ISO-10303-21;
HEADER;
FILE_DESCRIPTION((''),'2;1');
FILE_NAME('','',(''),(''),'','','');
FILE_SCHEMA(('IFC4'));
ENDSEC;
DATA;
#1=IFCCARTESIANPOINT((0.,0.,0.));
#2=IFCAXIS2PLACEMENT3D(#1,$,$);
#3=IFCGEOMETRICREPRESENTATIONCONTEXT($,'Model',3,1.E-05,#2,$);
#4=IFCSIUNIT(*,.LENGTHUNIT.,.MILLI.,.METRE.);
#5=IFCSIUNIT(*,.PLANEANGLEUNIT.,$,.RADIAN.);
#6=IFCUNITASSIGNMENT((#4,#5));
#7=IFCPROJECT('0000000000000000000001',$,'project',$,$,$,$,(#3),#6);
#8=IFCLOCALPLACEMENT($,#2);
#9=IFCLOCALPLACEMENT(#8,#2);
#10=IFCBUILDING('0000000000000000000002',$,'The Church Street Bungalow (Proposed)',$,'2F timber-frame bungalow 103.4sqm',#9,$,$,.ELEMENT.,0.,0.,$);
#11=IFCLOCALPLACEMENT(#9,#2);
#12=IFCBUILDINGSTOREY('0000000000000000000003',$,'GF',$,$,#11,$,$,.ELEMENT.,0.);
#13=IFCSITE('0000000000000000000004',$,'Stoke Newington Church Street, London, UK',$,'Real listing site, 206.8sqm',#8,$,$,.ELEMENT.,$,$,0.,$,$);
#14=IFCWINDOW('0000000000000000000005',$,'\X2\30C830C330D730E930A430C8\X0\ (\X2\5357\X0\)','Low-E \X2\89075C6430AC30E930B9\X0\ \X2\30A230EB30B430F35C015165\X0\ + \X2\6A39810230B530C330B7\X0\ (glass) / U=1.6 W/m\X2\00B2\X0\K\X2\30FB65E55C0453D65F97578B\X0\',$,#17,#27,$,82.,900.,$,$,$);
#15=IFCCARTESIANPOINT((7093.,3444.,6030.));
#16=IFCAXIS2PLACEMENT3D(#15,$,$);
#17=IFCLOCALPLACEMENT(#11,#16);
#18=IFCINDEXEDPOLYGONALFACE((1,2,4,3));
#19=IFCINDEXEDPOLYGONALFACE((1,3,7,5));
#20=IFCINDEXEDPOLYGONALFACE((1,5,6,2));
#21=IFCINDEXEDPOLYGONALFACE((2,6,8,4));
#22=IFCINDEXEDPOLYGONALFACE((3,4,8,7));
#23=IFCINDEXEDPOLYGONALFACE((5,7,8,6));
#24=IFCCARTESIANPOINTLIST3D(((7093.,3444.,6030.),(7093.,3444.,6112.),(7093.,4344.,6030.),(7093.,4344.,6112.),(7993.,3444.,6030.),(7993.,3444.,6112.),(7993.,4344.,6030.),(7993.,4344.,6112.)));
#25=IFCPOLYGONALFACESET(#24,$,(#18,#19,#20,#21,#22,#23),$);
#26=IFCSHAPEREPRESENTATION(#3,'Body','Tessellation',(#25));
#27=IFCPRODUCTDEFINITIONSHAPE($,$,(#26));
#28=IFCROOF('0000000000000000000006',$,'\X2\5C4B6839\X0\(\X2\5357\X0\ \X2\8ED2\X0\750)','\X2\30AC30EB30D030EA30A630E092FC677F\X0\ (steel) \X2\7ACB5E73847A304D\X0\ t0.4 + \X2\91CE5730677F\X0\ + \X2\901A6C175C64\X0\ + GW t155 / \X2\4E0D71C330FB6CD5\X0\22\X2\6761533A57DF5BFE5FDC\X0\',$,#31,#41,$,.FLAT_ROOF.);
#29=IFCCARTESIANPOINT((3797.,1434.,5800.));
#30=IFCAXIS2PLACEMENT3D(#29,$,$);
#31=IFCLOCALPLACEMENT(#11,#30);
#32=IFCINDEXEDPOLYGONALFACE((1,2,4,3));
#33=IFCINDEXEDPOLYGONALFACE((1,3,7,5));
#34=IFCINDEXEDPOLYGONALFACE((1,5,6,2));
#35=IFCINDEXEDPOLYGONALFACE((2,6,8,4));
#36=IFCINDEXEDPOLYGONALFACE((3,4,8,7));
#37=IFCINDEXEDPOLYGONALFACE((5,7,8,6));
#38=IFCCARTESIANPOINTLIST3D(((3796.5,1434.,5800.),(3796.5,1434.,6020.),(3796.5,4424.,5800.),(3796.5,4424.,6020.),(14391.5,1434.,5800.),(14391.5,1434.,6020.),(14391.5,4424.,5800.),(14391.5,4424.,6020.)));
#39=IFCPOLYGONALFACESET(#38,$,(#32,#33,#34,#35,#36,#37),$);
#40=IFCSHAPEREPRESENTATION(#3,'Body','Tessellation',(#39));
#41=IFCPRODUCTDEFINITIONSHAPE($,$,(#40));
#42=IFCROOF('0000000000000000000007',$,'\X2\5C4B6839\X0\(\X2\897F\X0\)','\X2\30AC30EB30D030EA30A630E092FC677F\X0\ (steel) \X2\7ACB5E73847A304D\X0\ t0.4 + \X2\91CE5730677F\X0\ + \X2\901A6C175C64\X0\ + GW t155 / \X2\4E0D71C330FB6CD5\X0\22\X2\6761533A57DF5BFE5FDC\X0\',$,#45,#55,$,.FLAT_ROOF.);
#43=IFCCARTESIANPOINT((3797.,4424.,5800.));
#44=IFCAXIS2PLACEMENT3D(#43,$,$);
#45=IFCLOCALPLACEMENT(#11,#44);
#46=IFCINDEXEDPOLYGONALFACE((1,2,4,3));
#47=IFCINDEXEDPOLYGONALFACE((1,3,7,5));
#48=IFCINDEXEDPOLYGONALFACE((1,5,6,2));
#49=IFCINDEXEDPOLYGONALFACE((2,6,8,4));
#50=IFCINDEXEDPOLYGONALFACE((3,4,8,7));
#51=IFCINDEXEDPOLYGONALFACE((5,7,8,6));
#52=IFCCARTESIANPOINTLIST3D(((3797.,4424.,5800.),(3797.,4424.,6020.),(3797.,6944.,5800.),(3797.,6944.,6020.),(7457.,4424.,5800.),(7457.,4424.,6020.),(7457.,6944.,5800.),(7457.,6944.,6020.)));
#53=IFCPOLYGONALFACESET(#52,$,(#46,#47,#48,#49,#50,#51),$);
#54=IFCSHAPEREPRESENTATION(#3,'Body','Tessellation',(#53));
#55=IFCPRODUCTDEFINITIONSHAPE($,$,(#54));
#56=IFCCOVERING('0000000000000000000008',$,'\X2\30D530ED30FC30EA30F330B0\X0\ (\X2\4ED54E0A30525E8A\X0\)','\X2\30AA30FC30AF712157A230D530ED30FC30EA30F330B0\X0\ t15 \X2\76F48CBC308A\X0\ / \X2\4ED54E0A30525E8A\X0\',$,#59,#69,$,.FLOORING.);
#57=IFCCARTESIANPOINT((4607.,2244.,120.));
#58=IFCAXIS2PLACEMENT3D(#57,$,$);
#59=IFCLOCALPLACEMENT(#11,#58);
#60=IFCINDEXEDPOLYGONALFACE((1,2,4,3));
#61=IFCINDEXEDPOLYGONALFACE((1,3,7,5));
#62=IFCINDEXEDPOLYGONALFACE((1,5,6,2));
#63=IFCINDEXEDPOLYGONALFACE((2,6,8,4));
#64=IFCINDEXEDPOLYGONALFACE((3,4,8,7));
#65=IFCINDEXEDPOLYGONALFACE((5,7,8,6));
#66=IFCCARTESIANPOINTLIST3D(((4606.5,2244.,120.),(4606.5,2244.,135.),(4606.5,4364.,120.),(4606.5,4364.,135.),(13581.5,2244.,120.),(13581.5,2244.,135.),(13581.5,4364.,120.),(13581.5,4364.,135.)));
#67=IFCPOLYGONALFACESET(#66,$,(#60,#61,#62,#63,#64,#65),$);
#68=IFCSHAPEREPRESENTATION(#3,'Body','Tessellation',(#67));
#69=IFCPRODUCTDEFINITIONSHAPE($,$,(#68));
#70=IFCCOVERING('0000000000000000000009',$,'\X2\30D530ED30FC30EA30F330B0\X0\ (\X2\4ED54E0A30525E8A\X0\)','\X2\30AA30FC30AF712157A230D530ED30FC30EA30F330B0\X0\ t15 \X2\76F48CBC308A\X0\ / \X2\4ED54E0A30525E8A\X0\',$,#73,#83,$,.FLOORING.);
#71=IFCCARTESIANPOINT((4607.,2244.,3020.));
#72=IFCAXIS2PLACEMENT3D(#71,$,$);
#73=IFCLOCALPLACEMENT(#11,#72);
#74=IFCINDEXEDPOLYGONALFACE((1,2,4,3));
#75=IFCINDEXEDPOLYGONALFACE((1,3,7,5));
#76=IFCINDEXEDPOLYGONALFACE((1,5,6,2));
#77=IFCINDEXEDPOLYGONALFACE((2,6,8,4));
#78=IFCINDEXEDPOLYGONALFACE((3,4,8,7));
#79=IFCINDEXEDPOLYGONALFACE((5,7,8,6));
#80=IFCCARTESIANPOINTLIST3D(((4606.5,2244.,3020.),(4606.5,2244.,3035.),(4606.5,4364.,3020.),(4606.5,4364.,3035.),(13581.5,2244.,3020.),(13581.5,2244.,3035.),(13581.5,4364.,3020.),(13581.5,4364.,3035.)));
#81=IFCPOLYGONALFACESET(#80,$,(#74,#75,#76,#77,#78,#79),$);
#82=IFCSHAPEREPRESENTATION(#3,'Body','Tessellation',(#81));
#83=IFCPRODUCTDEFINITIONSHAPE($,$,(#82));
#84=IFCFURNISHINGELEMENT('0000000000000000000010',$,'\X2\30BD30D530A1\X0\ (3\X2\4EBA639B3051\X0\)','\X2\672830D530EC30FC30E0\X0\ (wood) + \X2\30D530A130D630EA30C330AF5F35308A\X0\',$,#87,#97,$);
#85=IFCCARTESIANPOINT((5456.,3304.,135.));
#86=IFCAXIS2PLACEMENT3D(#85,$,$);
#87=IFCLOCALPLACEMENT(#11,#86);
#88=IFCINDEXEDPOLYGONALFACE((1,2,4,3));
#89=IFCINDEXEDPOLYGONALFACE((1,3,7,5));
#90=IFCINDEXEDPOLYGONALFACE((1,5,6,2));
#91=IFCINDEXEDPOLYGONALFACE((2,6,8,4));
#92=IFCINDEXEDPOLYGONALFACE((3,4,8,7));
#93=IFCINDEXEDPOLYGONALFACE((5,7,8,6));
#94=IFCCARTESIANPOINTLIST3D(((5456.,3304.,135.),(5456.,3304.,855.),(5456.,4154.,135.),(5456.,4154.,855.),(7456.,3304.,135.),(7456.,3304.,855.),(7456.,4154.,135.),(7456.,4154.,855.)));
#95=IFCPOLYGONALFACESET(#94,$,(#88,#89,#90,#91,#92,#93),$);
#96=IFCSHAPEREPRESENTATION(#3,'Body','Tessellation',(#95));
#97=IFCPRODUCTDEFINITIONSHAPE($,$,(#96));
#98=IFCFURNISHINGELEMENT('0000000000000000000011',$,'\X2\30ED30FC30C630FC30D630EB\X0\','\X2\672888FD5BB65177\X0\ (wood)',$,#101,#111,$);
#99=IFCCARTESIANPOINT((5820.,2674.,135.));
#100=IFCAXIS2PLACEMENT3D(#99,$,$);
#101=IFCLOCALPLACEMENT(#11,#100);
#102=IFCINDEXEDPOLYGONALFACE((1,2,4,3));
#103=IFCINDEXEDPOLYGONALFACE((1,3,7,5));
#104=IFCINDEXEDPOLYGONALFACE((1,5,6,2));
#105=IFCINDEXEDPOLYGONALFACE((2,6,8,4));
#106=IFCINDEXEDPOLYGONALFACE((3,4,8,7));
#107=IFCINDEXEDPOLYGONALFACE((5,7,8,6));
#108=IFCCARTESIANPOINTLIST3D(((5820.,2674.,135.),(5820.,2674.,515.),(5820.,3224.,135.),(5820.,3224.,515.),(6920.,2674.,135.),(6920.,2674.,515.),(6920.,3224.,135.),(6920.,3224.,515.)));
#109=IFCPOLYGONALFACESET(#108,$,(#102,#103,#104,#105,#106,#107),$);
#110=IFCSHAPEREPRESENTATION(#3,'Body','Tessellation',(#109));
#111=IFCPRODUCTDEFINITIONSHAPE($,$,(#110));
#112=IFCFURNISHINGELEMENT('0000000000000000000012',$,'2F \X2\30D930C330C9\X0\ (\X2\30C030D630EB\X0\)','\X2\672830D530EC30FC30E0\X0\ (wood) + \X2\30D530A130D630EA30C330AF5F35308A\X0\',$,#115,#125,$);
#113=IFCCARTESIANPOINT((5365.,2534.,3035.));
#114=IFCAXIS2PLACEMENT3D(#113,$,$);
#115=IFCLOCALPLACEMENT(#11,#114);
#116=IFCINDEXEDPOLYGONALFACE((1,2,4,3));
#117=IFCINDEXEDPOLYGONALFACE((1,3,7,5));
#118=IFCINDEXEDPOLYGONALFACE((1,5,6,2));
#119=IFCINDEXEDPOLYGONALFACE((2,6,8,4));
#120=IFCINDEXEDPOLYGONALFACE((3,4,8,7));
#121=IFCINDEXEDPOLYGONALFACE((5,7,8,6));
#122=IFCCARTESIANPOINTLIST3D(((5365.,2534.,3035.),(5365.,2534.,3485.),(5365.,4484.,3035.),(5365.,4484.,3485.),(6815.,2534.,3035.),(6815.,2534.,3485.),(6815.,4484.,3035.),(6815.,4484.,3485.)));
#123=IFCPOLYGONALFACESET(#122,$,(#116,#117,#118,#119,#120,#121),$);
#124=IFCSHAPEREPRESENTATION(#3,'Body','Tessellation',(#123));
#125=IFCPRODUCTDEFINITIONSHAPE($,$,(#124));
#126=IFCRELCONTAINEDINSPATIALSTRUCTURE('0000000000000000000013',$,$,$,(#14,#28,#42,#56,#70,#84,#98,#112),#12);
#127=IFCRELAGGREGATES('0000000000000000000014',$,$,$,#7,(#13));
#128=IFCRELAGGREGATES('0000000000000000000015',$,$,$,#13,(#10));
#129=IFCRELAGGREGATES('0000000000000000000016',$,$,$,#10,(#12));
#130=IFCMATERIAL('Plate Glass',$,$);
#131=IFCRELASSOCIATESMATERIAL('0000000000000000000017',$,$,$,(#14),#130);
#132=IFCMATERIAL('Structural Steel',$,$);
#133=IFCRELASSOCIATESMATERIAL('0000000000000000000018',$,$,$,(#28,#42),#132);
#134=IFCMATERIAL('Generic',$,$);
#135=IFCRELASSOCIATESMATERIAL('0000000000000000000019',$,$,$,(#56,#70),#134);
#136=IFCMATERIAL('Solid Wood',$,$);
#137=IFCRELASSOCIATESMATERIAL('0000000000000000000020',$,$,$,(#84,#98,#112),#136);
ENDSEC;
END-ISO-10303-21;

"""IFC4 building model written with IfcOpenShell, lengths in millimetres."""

from ifc_helpers import new_model, si_unit, frame, frame_2d, origin, place, context, project, spatial, rectangle, extrude, material, element, save


model = new_model("IFC4")

# Units and contexts
model_context = context("Model", 3, precision=1e-05, world=origin())
ifc_project = project(units=[si_unit("LENGTHUNIT", "METRE", prefix="MILLI"), si_unit("PLANEANGLEUNIT", "RADIAN")], contexts=[model_context])

# Site, building, storey
site_placement = place(None, origin())
site = spatial("IfcSite", under=ifc_project, at=site_placement, Name="Stoke Newington Church Street, London, UK", ObjectType="Real listing site, 206.8sqm", CompositionType="ELEMENT", RefElevation=0.0)
building_placement = place(site_placement, origin())
building = spatial("IfcBuilding", under=site, at=building_placement, Name="The Church Street Bungalow (Proposed)", ObjectType="2F timber-frame bungalow 103.4sqm", CompositionType="ELEMENT", ElevationOfRefHeight=0.0, ElevationOfTerrain=0.0)
storey_placement = place(building_placement, origin())
storey = spatial("IfcBuildingStorey", under=building, at=storey_placement, Name="GF", CompositionType="ELEMENT", Elevation=0.0)

# Shared definitions
ifc_material_1 = material(Name="Solid Wood")

# Shared definitions
ifc_material_2 = material(Name="Plate Glass")

# Window
window_1_placement = place(storey_placement, frame((7093.0, 3444.0, 6030.0)))
element("IfcWindow", 1, at=window_1_placement, inside=storey, material=ifc_material_2, Name="トップライト (南)", Description="Low-E 複層ガラス アルゴン封入 + 樹脂サッシ (glass) / U=1.6 W/m²K・日射取得型", OverallHeight=82.0, OverallWidth=900.0, context=model_context, shape_type="SweptSolid", body=[
    extrude(rectangle(XDim=900.0, YDim=900.0, at=frame_2d((450.0, 450.0))), frame((7093.0, 3444.0, 6030.0)), (0.0, 0.0, 1.0), 82.0),
])

# Roofs
ifc_material_3 = material(Name="Structural Steel")
roof_1_placement = place(storey_placement, frame((3797.0, 1434.0, 5800.0)))
element("IfcRoof", 2, at=roof_1_placement, inside=storey, material=ifc_material_3, Name="屋根(南 軒750)", Description="ガルバリウム鋼板 (steel) 立平葺き t0.4 + 野地板 + 通気層 + GW t155 / 不燃・法22条区域対応", PredefinedType="FLAT_ROOF", context=model_context, shape_type="SweptSolid", body=[
    extrude(rectangle(XDim=10595.0, YDim=2990.0, at=frame_2d((5297.0, 1495.0))), frame((3797.0, 1434.0, 5800.0)), (0.0, 0.0, 1.0), 220.0),
])
roof_2_placement = place(storey_placement, frame((3797.0, 4424.0, 5800.0)))
element("IfcRoof", 3, at=roof_2_placement, inside=storey, material=ifc_material_3, Name="屋根(西)", Description="ガルバリウム鋼板 (steel) 立平葺き t0.4 + 野地板 + 通気層 + GW t155 / 不燃・法22条区域対応", PredefinedType="FLAT_ROOF", context=model_context, shape_type="SweptSolid", body=[
    extrude(rectangle(XDim=3660.0, YDim=2520.0, at=frame_2d((1830.0, 1260.0))), frame((3797.0, 4424.0, 5800.0)), (0.0, 0.0, 1.0), 220.0),
])

# Coverings
ifc_material_4 = material(Name="Generic")
covering_1_placement = place(storey_placement, frame((4607.0, 2244.0, 120.0)))
element("IfcCovering", 4, at=covering_1_placement, inside=storey, material=ifc_material_4, Name="フローリング (仕上げ床)", Description="オーク無垢フローリング t15 直貼り / 仕上げ床", PredefinedType="FLOORING", context=model_context, shape_type="SweptSolid", body=[
    extrude(rectangle(XDim=8975.0, YDim=2120.0, at=frame_2d((4487.0, 1060.0))), frame((4607.0, 2244.0, 120.0)), (0.0, 0.0, 1.0), 15.0),
])
covering_2_placement = place(storey_placement, frame((4607.0, 2244.0, 3020.0)))
element("IfcCovering", 5, at=covering_2_placement, inside=storey, material=ifc_material_4, Name="フローリング (仕上げ床)", Description="オーク無垢フローリング t15 直貼り / 仕上げ床", PredefinedType="FLOORING", context=model_context, shape_type="SweptSolid", body=[
    extrude(rectangle(XDim=8975.0, YDim=2120.0, at=frame_2d((4487.0, 1060.0))), frame((4607.0, 2244.0, 3020.0)), (0.0, 0.0, 1.0), 15.0),
])

# Furnishing elements
furnishing_1_placement = place(storey_placement, frame((5456.0, 3304.0, 135.0)))
element("IfcFurnishingElement", 6, at=furnishing_1_placement, inside=storey, material=ifc_material_1, Name="ソファ (3人掛け)", Description="木フレーム (wood) + ファブリック張り", context=model_context, shape_type="SweptSolid", body=[
    extrude(rectangle(XDim=2000.0, YDim=850.0, at=frame_2d((1000.0, 425.0))), frame((5456.0, 3304.0, 135.0)), (0.0, 0.0, 1.0), 720.0),
])
furnishing_2_placement = place(storey_placement, frame((5820.0, 2674.0, 135.0)))
element("IfcFurnishingElement", 7, at=furnishing_2_placement, inside=storey, material=ifc_material_1, Name="ローテーブル", Description="木製家具 (wood)", context=model_context, shape_type="SweptSolid", body=[
    extrude(rectangle(XDim=1100.0, YDim=550.0, at=frame_2d((550.0, 275.0))), frame((5820.0, 2674.0, 135.0)), (0.0, 0.0, 1.0), 380.0),
])
furnishing_3_placement = place(storey_placement, frame((5365.0, 2534.0, 3035.0)))
element("IfcFurnishingElement", 8, at=furnishing_3_placement, inside=storey, material=ifc_material_1, Name="2F ベッド (ダブル)", Description="木フレーム (wood) + ファブリック張り", context=model_context, shape_type="SweptSolid", body=[
    extrude(rectangle(XDim=1450.0, YDim=1950.0, at=frame_2d((725.0, 975.0))), frame((5365.0, 2534.0, 3035.0)), (0.0, 0.0, 1.0), 450.0),
])

save(model, "model.ifc")
